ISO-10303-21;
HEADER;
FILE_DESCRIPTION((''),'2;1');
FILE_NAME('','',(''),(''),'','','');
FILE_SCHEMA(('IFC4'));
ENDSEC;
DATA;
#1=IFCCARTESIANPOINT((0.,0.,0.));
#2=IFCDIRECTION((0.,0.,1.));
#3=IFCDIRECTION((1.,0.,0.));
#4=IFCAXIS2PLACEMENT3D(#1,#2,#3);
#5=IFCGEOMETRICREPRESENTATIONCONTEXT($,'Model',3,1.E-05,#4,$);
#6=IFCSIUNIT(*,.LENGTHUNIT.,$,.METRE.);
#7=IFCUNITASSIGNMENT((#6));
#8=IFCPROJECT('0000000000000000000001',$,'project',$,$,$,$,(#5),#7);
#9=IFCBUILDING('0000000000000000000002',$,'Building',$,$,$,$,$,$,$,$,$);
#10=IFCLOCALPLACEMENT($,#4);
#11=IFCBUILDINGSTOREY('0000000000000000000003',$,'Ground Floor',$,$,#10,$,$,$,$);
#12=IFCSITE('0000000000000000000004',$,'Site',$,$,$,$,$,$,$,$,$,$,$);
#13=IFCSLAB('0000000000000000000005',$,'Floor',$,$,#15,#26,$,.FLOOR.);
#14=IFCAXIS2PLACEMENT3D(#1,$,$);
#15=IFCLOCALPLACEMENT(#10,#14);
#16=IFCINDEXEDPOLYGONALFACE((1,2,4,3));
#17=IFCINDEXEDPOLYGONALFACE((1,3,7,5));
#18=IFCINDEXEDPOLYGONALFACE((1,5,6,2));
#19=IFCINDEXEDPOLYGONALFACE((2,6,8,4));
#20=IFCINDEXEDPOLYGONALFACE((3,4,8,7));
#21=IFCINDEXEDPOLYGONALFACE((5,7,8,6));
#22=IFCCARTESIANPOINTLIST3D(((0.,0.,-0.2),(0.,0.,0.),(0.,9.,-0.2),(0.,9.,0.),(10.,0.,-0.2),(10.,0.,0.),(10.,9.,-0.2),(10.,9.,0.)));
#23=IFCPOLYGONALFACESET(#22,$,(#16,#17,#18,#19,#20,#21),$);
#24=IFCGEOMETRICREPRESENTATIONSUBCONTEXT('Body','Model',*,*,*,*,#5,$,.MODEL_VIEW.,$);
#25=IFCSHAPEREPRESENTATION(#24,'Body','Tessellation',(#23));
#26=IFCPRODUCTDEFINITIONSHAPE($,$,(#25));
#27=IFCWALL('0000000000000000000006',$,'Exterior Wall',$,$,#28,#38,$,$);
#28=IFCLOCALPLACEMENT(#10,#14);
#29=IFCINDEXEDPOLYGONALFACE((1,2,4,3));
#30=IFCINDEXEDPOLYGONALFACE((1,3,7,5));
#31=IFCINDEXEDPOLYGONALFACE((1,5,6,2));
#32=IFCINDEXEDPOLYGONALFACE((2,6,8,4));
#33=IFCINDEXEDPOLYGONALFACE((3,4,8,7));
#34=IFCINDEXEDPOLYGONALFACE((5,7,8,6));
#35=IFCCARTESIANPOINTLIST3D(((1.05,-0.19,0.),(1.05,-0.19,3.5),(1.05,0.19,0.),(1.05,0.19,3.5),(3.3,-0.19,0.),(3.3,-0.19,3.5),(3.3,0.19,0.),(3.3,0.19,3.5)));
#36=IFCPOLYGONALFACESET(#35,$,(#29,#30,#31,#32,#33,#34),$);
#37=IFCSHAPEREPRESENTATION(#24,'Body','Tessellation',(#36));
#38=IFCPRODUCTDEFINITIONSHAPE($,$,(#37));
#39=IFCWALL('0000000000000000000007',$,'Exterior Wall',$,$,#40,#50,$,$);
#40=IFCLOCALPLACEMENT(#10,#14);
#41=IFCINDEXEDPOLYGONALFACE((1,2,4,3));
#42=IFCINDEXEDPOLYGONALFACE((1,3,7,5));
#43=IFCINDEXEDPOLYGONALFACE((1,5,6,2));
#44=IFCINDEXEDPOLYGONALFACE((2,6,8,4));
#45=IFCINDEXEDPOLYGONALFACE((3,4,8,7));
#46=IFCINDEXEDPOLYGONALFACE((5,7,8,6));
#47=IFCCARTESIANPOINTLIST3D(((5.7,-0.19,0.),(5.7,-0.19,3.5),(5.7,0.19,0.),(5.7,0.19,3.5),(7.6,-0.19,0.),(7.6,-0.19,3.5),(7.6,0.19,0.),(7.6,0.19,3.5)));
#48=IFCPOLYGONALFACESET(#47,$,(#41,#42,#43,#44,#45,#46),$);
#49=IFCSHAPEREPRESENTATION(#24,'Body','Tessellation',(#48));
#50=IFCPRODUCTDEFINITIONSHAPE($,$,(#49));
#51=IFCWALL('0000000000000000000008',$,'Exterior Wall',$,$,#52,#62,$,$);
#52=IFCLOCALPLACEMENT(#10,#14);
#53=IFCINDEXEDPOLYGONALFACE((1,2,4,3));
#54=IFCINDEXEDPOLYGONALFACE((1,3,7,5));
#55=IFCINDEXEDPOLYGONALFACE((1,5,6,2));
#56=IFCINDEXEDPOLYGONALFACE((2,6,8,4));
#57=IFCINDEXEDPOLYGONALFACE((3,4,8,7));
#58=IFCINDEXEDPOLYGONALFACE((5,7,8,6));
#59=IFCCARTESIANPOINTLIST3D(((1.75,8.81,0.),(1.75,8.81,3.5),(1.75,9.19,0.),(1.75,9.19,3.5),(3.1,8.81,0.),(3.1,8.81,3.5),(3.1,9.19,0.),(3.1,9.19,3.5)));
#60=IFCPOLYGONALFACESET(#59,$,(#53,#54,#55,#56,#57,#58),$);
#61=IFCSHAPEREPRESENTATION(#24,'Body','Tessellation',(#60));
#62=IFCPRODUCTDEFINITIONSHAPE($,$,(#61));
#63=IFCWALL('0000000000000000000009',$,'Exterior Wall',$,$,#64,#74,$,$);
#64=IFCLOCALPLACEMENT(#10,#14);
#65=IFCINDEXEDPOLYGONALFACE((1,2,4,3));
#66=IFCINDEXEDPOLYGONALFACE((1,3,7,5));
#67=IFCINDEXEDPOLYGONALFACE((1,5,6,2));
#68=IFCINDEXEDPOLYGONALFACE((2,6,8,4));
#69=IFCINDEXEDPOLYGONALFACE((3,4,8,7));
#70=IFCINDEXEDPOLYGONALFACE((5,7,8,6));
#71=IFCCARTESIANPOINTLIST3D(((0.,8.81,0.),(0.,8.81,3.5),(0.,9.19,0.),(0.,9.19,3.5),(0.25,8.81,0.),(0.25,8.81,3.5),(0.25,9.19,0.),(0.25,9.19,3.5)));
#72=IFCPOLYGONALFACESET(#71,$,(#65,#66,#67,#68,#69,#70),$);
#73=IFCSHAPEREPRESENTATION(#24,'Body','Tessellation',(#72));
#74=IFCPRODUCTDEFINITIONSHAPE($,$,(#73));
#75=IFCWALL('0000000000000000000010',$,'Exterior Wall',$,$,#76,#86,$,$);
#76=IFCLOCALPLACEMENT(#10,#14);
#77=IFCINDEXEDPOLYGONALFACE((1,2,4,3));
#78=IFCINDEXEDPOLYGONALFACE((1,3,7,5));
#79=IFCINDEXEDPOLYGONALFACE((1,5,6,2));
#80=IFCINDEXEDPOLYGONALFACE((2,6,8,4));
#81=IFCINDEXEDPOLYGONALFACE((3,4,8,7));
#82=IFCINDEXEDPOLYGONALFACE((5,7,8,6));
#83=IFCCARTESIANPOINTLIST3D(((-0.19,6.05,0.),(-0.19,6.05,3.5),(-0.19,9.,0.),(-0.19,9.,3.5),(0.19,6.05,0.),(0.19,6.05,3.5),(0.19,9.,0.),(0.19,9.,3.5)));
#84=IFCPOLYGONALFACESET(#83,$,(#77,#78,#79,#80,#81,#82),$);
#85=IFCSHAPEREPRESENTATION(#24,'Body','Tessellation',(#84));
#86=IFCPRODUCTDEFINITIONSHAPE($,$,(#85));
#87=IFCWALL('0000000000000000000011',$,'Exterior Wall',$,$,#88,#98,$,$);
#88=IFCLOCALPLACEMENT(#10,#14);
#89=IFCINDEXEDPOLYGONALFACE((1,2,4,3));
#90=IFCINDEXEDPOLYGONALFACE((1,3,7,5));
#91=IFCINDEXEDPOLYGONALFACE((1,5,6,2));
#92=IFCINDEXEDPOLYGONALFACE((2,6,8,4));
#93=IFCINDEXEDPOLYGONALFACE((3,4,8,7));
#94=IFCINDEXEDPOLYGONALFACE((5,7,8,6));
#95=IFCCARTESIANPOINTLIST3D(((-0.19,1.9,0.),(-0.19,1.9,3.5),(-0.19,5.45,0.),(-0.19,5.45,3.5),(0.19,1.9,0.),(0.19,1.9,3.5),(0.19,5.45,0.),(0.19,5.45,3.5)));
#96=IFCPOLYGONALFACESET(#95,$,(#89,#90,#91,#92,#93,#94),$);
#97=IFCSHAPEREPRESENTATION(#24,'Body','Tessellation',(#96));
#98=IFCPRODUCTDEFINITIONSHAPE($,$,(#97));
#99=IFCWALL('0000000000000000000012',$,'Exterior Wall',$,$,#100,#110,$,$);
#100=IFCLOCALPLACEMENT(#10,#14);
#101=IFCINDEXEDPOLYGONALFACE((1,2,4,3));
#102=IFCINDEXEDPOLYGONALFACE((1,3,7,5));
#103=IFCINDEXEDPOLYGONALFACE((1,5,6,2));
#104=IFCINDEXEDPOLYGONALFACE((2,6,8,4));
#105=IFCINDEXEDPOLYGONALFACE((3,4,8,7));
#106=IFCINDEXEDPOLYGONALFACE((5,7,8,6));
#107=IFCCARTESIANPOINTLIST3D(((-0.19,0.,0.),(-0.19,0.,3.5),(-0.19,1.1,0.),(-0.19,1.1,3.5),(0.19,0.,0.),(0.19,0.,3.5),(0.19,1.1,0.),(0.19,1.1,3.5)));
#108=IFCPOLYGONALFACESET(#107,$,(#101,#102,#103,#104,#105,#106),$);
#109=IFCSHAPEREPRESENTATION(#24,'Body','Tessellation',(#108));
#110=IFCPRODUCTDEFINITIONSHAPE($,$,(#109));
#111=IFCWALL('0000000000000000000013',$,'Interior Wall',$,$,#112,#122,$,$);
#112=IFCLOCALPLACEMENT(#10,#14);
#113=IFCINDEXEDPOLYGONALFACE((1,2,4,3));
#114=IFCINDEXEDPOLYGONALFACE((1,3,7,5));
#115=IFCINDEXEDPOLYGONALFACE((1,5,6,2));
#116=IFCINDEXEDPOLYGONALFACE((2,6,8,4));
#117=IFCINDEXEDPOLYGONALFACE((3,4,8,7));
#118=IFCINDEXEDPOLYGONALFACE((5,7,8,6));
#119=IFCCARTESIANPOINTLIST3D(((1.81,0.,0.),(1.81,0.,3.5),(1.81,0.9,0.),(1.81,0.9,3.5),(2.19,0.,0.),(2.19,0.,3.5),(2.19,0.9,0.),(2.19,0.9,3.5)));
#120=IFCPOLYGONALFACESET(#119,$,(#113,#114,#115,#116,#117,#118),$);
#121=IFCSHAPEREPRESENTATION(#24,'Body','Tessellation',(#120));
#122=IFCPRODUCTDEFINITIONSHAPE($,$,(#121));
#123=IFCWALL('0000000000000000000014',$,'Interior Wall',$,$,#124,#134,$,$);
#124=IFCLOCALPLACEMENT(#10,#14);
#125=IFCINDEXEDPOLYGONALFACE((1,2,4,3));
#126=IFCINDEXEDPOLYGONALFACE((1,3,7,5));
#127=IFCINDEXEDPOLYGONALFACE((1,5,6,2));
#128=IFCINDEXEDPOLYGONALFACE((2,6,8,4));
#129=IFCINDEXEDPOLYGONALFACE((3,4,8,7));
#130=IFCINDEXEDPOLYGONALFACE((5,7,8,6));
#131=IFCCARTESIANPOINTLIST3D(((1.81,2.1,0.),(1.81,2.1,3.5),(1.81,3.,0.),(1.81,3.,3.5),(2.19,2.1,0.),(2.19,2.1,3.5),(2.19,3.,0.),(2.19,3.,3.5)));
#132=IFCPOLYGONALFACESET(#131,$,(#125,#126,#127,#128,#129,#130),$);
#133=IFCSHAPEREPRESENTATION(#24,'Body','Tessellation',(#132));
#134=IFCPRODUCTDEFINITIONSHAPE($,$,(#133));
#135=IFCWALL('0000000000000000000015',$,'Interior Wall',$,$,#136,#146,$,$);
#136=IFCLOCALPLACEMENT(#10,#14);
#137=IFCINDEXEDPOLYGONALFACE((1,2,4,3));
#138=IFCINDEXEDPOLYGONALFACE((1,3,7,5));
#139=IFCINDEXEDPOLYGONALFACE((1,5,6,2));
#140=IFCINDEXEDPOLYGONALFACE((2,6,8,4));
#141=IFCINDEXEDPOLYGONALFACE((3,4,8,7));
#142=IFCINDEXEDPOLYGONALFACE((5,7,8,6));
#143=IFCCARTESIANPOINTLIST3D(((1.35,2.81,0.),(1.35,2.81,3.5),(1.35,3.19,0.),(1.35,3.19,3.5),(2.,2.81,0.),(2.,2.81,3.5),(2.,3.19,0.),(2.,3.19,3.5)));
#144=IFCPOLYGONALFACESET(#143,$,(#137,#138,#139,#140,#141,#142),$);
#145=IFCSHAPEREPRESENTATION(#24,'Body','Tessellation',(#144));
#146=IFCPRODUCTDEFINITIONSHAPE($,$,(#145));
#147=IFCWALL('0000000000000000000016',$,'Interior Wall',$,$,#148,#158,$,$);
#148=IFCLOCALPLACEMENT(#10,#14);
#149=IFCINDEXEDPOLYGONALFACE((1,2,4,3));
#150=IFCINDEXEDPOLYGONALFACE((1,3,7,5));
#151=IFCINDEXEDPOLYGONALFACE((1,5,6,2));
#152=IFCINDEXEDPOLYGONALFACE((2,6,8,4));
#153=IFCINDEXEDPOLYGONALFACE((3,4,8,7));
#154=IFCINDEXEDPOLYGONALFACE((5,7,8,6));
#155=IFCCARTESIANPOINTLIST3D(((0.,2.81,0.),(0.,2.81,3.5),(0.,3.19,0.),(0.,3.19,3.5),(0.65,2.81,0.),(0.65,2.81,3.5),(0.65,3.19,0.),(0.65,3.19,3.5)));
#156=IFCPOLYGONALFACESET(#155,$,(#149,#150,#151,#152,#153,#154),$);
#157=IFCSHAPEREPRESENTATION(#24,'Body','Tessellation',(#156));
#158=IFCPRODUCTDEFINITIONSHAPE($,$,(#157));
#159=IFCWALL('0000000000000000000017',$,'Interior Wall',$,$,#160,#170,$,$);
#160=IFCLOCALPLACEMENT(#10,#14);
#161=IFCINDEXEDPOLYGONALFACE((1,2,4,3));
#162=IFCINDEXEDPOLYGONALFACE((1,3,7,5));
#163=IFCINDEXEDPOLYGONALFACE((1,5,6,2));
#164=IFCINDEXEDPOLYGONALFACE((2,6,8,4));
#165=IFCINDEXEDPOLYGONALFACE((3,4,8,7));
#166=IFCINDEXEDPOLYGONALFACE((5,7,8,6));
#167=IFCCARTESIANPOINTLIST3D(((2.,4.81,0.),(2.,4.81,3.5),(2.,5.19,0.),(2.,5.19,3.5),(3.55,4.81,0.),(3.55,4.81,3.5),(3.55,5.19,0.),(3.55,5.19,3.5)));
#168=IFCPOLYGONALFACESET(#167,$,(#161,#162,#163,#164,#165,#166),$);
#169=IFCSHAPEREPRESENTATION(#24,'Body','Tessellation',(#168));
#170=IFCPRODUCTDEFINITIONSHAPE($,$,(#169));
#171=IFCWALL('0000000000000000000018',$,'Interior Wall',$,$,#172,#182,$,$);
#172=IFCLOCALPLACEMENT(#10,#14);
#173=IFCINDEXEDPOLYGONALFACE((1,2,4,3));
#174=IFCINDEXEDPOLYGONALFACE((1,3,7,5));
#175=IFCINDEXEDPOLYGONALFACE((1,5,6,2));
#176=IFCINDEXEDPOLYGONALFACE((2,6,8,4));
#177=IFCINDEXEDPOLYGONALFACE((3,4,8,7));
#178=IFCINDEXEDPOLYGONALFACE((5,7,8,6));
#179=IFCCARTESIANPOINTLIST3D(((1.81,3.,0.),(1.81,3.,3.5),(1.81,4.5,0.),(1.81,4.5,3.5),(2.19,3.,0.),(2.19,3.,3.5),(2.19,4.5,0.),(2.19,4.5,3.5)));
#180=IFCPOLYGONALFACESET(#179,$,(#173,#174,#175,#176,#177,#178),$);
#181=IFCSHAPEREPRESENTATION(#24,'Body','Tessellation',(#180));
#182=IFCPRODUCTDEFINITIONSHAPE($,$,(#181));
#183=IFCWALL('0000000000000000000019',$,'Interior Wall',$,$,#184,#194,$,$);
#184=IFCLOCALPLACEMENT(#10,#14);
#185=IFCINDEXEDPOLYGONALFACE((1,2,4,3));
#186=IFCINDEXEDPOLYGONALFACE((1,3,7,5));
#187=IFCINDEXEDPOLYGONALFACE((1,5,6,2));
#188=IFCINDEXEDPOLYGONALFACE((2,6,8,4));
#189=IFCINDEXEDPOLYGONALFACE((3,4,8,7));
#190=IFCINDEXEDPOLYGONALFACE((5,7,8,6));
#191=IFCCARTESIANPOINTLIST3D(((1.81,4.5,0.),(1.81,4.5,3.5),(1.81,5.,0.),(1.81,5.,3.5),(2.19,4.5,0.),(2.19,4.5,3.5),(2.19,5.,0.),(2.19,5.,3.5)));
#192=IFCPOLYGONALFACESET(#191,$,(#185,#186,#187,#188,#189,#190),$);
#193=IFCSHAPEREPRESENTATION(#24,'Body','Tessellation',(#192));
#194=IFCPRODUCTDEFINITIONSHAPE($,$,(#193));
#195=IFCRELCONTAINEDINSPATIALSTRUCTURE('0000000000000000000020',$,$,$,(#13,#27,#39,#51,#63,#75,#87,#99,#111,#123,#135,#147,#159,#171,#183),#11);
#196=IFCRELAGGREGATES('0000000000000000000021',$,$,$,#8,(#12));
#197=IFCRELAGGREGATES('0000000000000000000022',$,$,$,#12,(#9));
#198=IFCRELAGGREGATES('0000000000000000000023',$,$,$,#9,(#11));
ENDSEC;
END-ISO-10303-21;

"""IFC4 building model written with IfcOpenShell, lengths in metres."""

from ifc_helpers import new_model, si_unit, frame, origin_with_axes, place, context, subcontext, project, spatial, indexed_curve, outline, extrude, element, save


model = new_model("IFC4")

# Units and contexts
model_context = context("Model", 3, precision=1e-05, world=origin_with_axes())
body_context = subcontext(model_context, "Body", "Model", "MODEL_VIEW")
ifc_project = project(units=[si_unit("LENGTHUNIT", "METRE")], contexts=[model_context])

# Site, building, storey
site = spatial("IfcSite", under=ifc_project, Name="Site")
building = spatial("IfcBuilding", under=site, Name="Building")
storey_placement = place(None, origin_with_axes())
storey = spatial("IfcBuildingStorey", under=building, at=storey_placement, Name="Ground Floor")

# Slab
slab_placement = place(storey_placement, frame((0.0, 0.0, -0.2), z_axis=(0.0, 0.0, 1.0), x_axis=(1.0, 0.0, 0.0)))
element("IfcSlab", 1, at=slab_placement, inside=storey, Name="Floor", PredefinedType="FLOOR", context=body_context, shape_type="SweptSolid", body=[
    extrude(outline(indexed_curve([(0.0, 0.0), (10.0, 0.0), (10.0, 9.0), (0.0, 9.0)])), None, (0.0, 0.0, 1.0), 0.2),
])

# Walls
wall_1_placement = place(storey_placement, frame((1.05, 0.0, 0.0), z_axis=(0.0, 0.0, 1.0), x_axis=(1.0, 0.0, 0.0)))
element("IfcWall", 2, at=wall_1_placement, inside=storey, Name="Exterior Wall", context=body_context, shape_type="SweptSolid", body=[
    extrude(outline(indexed_curve([(0.0, 0.0), (0.0, 0.38), (2.25, 0.38), (2.25, 0.0), (0.0, 0.0)], self_intersect=False)), frame((0.0, -0.19, 0.0), z_axis=(0.0, 0.0, 1.0), x_axis=(1.0, 0.0, 0.0)), (0.0, 0.0, 1.0), 3.5),
])
wall_2_placement = place(storey_placement, frame((5.7, 0.0, 0.0), z_axis=(0.0, 0.0, 1.0), x_axis=(1.0, 0.0, 0.0)))
element("IfcWall", 3, at=wall_2_placement, inside=storey, Name="Exterior Wall", context=body_context, shape_type="SweptSolid", body=[
    extrude(outline(indexed_curve([(0.0, 0.0), (0.0, 0.38), (1.9, 0.38), (1.9, 0.0), (0.0, 0.0)], self_intersect=False)), frame((0.0, -0.19, 0.0), z_axis=(0.0, 0.0, 1.0), x_axis=(1.0, 0.0, 0.0)), (0.0, 0.0, 1.0), 3.5),
])
wall_3_placement = place(storey_placement, frame((3.1, 9.0, 0.0), z_axis=(0.0, 0.0, 1.0), x_axis=(-1.0, 0.0, 0.0)))
element("IfcWall", 4, at=wall_3_placement, inside=storey, Name="Exterior Wall", context=body_context, shape_type="SweptSolid", body=[
    extrude(outline(indexed_curve([(0.0, 0.0), (0.0, 0.38), (1.35, 0.38), (1.35, 0.0), (0.0, 0.0)], self_intersect=False)), frame((0.0, -0.19, 0.0), z_axis=(0.0, 0.0, 1.0), x_axis=(1.0, 0.0, 0.0)), (0.0, 0.0, 1.0), 3.5),
])
wall_4_placement = place(storey_placement, frame((0.25, 9.0, 0.0), z_axis=(0.0, 0.0, 1.0), x_axis=(-1.0, 0.0, 0.0)))
element("IfcWall", 5, at=wall_4_placement, inside=storey, Name="Exterior Wall", context=body_context, shape_type="SweptSolid", body=[
    extrude(outline(indexed_curve([(0.0, 0.0), (0.0, 0.38), (0.25, 0.38), (0.25, 0.0), (0.0, 0.0)], self_intersect=False)), frame((0.0, -0.19, 0.0), z_axis=(0.0, 0.0, 1.0), x_axis=(1.0, 0.0, 0.0)), (0.0, 0.0, 1.0), 3.5),
])
wall_5_placement = place(storey_placement, frame((0.0, 9.0, 0.0), z_axis=(0.0, 0.0, 1.0), x_axis=(0.0, -1.0, 0.0)))
element("IfcWall", 6, at=wall_5_placement, inside=storey, Name="Exterior Wall", context=body_context, shape_type="SweptSolid", body=[
    extrude(outline(indexed_curve([(0.0, 0.0), (0.0, 0.38), (2.95, 0.38), (2.95, 0.0), (0.0, 0.0)], self_intersect=False)), frame((0.0, -0.19, 0.0), z_axis=(0.0, 0.0, 1.0), x_axis=(1.0, 0.0, 0.0)), (0.0, 0.0, 1.0), 3.5),
])
wall_6_placement = place(storey_placement, frame((0.0, 5.45, 0.0), z_axis=(0.0, 0.0, 1.0), x_axis=(0.0, -1.0, 0.0)))
element("IfcWall", 7, at=wall_6_placement, inside=storey, Name="Exterior Wall", context=body_context, shape_type="SweptSolid", body=[
    extrude(outline(indexed_curve([(0.0, 0.0), (0.0, 0.38), (3.55, 0.38), (3.55, 0.0), (0.0, 0.0)], self_intersect=False)), frame((0.0, -0.19, 0.0), z_axis=(0.0, 0.0, 1.0), x_axis=(1.0, 0.0, 0.0)), (0.0, 0.0, 1.0), 3.5),
])
wall_7_placement = place(storey_placement, frame((0.0, 1.1, 0.0), z_axis=(0.0, 0.0, 1.0), x_axis=(0.0, -1.0, 0.0)))
element("IfcWall", 8, at=wall_7_placement, inside=storey, Name="Exterior Wall", context=body_context, shape_type="SweptSolid", body=[
    extrude(outline(indexed_curve([(0.0, 0.0), (0.0, 0.38), (1.1, 0.38), (1.1, 0.0), (0.0, 0.0)], self_intersect=False)), frame((0.0, -0.19, 0.0), z_axis=(0.0, 0.0, 1.0), x_axis=(1.0, 0.0, 0.0)), (0.0, 0.0, 1.0), 3.5),
])
wall_8_placement = place(storey_placement, frame((2.0, 0.0, 0.0), z_axis=(0.0, 0.0, 1.0), x_axis=(0.0, 1.0, 0.0)))
element("IfcWall", 9, at=wall_8_placement, inside=storey, Name="Interior Wall", context=body_context, shape_type="SweptSolid", body=[
    extrude(outline(indexed_curve([(0.0, 0.0), (0.0, 0.38), (0.9, 0.38), (0.9, 0.0), (0.0, 0.0)], self_intersect=False)), frame((0.0, -0.19, 0.0), z_axis=(0.0, 0.0, 1.0), x_axis=(1.0, 0.0, 0.0)), (0.0, 0.0, 1.0), 3.5),
])
wall_9_placement = place(storey_placement, frame((2.0, 2.1, 0.0), z_axis=(0.0, 0.0, 1.0), x_axis=(0.0, 1.0, 0.0)))
element("IfcWall", 10, at=wall_9_placement, inside=storey, Name="Interior Wall", context=body_context, shape_type="SweptSolid", body=[
    extrude(outline(indexed_curve([(0.0, 0.0), (0.0, 0.38), (0.9, 0.38), (0.9, 0.0), (0.0, 0.0)], self_intersect=False)), frame((0.0, -0.19, 0.0), z_axis=(0.0, 0.0, 1.0), x_axis=(1.0, 0.0, 0.0)), (0.0, 0.0, 1.0), 3.5),
])
for number, where, z_axis, x_axis, name in (
    (11, (2.0, 3.0, 0.0), (0.0, 0.0, 1.0), (-1.0, 0.0, 0.0), "Interior Wall"),
    (12, (0.65, 3.0, 0.0), (0.0, 0.0, 1.0), (-1.0, 0.0, 0.0), "Interior Wall"),
):
    element("IfcWall", number, at=place(storey_placement, frame(where, z_axis=z_axis, x_axis=x_axis)), inside=storey, Name=name, context=body_context, shape_type="SweptSolid", body=[
        extrude(outline(indexed_curve([(0.0, 0.0), (0.0, 0.38), (0.65, 0.38), (0.65, 0.0), (0.0, 0.0)], self_intersect=False)), frame((0.0, -0.19, 0.0), z_axis=(0.0, 0.0, 1.0), x_axis=(1.0, 0.0, 0.0)), (0.0, 0.0, 1.0), 3.5),
    ])
wall_10_placement = place(storey_placement, frame((3.55, 5.0, 0.0), z_axis=(0.0, 0.0, 1.0), x_axis=(-1.0, 0.0, 0.0)))
element("IfcWall", 13, at=wall_10_placement, inside=storey, Name="Interior Wall", context=body_context, shape_type="SweptSolid", body=[
    extrude(outline(indexed_curve([(0.0, 0.0), (0.0, 0.38), (1.55, 0.38), (1.55, 0.0), (0.0, 0.0)], self_intersect=False)), frame((0.0, -0.19, 0.0), z_axis=(0.0, 0.0, 1.0), x_axis=(1.0, 0.0, 0.0)), (0.0, 0.0, 1.0), 3.5),
])
wall_11_placement = place(storey_placement, frame((2.0, 4.5, 0.0), z_axis=(0.0, 0.0, 1.0), x_axis=(0.0, -1.0, 0.0)))
element("IfcWall", 14, at=wall_11_placement, inside=storey, Name="Interior Wall", context=body_context, shape_type="SweptSolid", body=[
    extrude(outline(indexed_curve([(0.0, 0.0), (0.0, 0.38), (1.5, 0.38), (1.5, 0.0), (0.0, 0.0)], self_intersect=False)), frame((0.0, -0.19, 0.0), z_axis=(0.0, 0.0, 1.0), x_axis=(1.0, 0.0, 0.0)), (0.0, 0.0, 1.0), 3.5),
])
wall_12_placement = place(storey_placement, frame((2.0, 5.0, 0.0), z_axis=(0.0, 0.0, 1.0), x_axis=(0.0, -1.0, 0.0)))
element("IfcWall", 15, at=wall_12_placement, inside=storey, Name="Interior Wall", context=body_context, shape_type="SweptSolid", body=[
    extrude(outline(indexed_curve([(0.0, 0.0), (0.0, 0.38), (0.5, 0.38), (0.5, 0.0), (0.0, 0.0)], self_intersect=False)), frame((0.0, -0.19, 0.0), z_axis=(0.0, 0.0, 1.0), x_axis=(1.0, 0.0, 0.0)), (0.0, 0.0, 1.0), 3.5),
])

save(model, "model.ifc")
